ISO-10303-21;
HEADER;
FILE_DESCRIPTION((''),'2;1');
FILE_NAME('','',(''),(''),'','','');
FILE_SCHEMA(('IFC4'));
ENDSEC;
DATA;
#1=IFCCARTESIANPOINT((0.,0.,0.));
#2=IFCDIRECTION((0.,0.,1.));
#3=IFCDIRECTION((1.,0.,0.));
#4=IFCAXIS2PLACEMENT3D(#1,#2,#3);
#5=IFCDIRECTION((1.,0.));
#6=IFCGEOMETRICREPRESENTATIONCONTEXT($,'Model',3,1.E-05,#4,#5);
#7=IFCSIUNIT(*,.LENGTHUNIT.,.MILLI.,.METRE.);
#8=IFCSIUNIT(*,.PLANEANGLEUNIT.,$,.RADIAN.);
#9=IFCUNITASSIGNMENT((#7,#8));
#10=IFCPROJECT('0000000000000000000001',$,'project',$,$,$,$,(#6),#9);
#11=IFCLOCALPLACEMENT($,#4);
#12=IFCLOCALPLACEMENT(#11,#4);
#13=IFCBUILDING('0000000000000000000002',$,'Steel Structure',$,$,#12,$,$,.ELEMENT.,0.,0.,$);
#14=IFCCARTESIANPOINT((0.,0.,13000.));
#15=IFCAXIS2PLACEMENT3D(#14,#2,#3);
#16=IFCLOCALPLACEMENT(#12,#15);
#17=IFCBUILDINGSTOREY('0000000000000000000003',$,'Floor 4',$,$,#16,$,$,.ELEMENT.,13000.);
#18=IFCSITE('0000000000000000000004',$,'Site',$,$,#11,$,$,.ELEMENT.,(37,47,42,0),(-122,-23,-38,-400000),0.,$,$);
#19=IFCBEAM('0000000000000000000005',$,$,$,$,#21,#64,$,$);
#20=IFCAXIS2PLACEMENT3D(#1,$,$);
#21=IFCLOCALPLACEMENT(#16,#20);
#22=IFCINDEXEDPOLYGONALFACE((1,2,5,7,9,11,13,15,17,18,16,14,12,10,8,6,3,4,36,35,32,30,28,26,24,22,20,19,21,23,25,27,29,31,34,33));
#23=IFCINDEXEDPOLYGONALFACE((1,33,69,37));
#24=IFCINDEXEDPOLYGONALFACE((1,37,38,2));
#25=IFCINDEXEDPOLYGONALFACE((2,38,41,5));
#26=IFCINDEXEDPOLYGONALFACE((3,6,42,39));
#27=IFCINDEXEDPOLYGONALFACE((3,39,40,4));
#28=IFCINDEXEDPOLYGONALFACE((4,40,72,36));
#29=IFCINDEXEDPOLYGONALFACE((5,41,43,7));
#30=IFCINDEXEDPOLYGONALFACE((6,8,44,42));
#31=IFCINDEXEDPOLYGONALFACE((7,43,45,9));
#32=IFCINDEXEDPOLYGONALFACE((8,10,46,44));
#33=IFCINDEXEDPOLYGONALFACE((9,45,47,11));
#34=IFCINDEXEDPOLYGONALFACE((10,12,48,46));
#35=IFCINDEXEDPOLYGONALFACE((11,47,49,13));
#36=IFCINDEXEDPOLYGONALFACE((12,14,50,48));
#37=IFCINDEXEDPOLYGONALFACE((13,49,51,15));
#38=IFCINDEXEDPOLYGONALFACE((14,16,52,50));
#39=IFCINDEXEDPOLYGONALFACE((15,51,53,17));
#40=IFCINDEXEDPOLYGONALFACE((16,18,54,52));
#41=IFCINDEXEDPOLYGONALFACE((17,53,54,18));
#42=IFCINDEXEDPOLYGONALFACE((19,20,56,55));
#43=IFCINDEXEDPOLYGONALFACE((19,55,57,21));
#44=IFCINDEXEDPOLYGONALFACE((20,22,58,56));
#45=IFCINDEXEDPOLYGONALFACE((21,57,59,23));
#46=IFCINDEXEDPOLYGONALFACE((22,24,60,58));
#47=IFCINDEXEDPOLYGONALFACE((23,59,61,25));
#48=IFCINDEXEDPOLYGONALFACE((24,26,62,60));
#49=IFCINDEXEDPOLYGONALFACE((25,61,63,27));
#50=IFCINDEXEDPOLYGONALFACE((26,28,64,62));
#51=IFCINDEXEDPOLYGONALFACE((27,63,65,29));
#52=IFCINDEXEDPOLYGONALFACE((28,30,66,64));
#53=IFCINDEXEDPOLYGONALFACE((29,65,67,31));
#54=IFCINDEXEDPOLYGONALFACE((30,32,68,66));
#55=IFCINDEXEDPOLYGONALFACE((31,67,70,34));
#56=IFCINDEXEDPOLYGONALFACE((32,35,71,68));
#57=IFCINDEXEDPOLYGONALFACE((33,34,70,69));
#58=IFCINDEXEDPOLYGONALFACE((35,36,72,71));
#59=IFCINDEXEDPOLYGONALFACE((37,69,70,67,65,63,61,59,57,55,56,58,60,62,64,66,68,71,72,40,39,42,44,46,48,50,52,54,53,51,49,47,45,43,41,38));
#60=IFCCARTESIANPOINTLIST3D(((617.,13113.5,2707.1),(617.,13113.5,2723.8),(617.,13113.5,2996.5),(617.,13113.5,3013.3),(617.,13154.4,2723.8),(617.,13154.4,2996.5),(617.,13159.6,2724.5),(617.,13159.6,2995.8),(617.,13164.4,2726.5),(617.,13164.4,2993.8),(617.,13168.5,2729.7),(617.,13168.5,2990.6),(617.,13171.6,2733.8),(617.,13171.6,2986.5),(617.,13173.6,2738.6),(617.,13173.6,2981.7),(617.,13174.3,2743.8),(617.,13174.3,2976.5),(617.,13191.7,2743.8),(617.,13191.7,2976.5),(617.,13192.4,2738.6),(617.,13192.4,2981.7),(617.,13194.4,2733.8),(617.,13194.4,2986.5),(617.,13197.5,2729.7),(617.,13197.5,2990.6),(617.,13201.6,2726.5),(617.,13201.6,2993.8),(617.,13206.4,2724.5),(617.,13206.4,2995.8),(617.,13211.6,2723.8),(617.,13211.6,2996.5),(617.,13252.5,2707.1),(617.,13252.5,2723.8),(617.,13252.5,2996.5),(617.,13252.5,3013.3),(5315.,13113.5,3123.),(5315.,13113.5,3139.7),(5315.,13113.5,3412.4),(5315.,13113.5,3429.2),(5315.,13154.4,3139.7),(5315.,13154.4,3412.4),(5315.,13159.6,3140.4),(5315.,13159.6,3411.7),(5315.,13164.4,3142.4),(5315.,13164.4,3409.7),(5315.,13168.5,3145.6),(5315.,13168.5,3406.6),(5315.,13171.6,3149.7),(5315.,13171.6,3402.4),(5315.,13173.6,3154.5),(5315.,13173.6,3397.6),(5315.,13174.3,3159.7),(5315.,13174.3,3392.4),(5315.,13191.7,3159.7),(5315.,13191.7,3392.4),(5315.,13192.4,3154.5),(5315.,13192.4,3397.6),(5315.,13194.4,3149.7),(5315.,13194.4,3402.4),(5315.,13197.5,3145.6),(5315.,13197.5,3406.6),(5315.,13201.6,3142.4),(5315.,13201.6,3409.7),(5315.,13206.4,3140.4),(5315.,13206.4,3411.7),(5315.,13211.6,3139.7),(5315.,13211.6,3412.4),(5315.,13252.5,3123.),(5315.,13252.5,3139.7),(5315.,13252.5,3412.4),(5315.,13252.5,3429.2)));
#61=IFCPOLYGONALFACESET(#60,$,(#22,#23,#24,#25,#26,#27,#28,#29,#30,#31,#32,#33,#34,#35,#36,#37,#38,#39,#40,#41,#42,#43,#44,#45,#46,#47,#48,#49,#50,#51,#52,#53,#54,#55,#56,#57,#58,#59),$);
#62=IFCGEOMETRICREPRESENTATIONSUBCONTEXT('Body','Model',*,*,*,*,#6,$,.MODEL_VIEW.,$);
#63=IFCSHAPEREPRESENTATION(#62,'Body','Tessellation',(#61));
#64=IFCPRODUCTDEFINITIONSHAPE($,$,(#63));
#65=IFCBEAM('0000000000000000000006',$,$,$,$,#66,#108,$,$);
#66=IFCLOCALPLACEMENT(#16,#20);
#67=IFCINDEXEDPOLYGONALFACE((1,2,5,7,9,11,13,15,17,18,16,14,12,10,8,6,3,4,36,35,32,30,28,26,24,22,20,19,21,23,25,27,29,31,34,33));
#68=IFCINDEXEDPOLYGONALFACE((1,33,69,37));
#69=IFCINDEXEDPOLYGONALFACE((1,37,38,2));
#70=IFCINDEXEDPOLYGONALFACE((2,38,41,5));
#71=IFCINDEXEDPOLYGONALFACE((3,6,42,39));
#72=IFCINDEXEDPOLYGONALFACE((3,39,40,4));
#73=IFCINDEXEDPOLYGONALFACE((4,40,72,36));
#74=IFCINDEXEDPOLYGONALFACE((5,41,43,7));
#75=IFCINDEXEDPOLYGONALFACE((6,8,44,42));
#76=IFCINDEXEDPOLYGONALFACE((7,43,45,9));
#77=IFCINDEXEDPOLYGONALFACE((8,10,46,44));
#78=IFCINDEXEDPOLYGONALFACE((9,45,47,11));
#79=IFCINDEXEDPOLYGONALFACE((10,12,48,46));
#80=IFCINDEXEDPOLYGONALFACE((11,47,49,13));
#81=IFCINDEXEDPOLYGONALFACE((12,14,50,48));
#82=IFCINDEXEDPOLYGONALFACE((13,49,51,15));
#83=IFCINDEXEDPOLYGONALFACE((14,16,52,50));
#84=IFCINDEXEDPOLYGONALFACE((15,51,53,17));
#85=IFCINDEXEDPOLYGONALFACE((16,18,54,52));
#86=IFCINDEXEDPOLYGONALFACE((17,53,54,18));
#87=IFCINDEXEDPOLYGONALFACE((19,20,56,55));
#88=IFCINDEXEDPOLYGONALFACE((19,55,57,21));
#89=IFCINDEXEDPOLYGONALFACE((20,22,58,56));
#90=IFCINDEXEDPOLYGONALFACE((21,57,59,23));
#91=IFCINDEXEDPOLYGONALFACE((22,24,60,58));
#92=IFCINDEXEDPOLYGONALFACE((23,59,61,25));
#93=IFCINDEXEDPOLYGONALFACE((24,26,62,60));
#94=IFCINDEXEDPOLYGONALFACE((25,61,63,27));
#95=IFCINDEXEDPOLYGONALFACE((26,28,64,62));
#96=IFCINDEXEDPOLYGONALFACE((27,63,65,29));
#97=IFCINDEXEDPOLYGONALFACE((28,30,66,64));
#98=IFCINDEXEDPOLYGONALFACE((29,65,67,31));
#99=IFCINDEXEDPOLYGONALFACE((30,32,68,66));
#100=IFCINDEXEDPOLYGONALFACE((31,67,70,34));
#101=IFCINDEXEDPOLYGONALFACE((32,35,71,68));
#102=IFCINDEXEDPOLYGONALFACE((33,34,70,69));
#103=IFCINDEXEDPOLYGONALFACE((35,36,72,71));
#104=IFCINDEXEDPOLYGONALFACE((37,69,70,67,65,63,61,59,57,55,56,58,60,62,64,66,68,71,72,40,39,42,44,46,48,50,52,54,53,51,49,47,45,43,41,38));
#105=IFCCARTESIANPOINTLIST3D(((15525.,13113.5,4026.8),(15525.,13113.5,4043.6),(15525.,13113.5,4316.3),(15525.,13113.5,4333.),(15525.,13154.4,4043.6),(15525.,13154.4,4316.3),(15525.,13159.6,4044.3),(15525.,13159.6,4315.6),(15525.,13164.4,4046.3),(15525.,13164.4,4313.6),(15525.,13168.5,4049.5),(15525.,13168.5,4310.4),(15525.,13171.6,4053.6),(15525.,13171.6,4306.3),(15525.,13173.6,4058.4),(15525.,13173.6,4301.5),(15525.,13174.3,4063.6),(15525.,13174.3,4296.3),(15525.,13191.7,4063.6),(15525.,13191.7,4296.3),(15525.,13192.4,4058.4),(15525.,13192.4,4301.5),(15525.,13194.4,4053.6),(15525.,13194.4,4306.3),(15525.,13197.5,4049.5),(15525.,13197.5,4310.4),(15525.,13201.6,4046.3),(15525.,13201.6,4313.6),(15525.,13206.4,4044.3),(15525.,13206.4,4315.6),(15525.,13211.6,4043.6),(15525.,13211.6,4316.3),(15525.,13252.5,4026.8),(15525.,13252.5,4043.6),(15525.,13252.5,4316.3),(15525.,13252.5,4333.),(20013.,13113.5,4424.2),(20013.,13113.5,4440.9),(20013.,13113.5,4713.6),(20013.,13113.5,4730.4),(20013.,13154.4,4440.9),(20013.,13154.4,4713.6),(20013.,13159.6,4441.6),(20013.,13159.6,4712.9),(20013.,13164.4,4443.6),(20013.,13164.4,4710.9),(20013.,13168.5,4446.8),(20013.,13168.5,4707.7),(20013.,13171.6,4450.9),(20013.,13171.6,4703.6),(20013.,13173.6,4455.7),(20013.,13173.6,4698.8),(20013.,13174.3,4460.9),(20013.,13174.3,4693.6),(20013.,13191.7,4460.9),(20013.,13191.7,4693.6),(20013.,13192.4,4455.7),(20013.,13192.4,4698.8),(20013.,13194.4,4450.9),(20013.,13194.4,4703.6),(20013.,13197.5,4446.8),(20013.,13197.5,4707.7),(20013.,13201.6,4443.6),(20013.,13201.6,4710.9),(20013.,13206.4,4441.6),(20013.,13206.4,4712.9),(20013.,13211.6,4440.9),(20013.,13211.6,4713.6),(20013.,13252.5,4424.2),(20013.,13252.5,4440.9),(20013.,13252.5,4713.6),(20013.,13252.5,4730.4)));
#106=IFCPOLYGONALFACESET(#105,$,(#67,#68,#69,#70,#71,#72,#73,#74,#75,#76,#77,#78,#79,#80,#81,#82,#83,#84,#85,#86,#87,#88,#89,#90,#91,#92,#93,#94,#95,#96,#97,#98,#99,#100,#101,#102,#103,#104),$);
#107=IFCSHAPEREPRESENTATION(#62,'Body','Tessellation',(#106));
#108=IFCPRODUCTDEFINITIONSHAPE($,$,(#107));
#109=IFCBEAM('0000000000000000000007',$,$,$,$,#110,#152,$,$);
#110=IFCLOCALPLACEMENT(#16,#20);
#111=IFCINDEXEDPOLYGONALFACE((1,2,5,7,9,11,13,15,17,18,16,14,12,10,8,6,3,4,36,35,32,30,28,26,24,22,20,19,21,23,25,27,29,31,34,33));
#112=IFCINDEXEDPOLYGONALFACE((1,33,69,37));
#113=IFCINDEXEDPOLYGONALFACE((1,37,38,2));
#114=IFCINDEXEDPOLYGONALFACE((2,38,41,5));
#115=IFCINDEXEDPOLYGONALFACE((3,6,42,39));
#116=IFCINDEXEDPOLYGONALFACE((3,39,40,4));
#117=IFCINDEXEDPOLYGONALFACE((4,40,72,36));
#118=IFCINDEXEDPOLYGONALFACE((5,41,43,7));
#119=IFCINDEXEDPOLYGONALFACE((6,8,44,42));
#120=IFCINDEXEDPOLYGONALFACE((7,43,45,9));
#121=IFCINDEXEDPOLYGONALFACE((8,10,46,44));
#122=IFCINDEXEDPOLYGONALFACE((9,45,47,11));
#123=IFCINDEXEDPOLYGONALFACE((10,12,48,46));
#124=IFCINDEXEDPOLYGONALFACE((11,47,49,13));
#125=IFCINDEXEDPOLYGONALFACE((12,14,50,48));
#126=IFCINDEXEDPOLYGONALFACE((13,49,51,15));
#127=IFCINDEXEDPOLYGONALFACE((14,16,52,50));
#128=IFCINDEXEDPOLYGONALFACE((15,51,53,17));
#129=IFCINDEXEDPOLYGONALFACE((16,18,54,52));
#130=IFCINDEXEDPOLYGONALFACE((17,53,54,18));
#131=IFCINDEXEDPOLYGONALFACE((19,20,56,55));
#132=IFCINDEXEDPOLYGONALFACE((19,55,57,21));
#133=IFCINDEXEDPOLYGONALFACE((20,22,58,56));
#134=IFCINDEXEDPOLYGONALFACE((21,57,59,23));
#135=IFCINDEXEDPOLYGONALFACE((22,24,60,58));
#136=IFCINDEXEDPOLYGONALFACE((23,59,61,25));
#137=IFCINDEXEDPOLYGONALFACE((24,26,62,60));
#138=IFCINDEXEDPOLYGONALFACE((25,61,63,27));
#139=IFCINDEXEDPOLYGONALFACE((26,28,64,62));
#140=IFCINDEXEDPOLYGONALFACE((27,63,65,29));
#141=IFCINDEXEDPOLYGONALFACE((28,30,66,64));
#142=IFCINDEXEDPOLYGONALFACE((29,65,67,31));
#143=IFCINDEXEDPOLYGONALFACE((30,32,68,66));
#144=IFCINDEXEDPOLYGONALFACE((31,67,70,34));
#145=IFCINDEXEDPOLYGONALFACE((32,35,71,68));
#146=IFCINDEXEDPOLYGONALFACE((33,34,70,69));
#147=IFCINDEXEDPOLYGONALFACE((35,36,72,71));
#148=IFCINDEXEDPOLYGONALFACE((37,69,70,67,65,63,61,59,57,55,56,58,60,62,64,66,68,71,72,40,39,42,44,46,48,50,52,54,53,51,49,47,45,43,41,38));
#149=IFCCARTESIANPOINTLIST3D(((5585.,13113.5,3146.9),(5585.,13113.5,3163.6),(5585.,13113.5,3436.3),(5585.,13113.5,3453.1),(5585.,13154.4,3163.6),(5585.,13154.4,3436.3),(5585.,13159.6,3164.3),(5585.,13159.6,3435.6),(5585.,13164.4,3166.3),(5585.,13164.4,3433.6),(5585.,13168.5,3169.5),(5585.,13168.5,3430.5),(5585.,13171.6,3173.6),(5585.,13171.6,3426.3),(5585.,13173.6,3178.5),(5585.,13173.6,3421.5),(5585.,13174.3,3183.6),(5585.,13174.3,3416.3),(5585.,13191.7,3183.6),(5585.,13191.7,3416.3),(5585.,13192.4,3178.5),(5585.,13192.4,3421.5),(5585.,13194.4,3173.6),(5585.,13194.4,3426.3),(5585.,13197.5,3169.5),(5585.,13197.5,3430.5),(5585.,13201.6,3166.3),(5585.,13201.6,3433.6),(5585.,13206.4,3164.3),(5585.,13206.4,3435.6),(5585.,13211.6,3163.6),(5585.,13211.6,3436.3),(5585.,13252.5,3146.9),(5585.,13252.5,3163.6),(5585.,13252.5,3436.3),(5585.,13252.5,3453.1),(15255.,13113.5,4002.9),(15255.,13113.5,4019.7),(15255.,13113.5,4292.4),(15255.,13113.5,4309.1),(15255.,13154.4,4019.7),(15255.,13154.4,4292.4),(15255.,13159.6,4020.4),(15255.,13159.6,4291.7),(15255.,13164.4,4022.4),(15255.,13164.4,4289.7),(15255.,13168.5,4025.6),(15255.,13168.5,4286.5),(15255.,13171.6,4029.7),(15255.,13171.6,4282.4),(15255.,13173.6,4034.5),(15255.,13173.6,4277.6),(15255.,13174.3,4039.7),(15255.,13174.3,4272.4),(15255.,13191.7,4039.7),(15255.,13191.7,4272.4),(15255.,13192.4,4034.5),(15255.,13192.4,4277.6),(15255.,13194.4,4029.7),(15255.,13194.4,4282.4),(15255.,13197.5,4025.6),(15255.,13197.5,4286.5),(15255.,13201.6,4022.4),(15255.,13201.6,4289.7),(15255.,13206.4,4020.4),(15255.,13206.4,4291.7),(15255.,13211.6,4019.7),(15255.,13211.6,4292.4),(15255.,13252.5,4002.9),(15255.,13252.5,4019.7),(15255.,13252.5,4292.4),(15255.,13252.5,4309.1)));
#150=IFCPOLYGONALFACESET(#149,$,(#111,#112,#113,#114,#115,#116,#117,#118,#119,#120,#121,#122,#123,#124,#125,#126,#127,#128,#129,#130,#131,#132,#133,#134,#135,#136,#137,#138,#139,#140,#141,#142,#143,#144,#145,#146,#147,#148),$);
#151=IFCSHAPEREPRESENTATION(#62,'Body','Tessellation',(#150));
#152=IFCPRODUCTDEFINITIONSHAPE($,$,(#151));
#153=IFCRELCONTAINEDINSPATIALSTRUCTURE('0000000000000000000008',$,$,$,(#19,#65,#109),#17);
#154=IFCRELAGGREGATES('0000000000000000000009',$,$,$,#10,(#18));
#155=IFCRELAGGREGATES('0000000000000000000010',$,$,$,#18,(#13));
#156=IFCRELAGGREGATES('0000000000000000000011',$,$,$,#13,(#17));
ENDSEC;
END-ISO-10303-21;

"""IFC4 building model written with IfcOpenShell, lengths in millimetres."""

from ifc_helpers import new_model, si_unit, direction, frame, origin_with_axes, origin_2d_with_axis, place, context, subcontext, project, spatial, polyline, i_section, extrude, clip, bounded_halfspace, element, save


model = new_model("IFC4")

# Units and contexts
model_context = context("Model", 3, precision=1e-05, world=origin_with_axes(), true_north=direction((1.0, 0.0)))
body_context = subcontext(model_context, "Body", "Model", "MODEL_VIEW")
ifc_project = project(units=[si_unit("LENGTHUNIT", "METRE", prefix="MILLI"), si_unit("PLANEANGLEUNIT", "RADIAN")], contexts=[model_context])

# Site, building, storey
site_placement = place(None, origin_with_axes())
site = spatial("IfcSite", under=ifc_project, at=site_placement, Name="Site", CompositionType="ELEMENT", RefLatitude=(37, 47, 42, 0), RefLongitude=(-122, -23, -38, -400000), RefElevation=0.0)
building_placement = place(site_placement, origin_with_axes())
building = spatial("IfcBuilding", under=site, at=building_placement, Name="Steel Structure", CompositionType="ELEMENT", ElevationOfRefHeight=0.0, ElevationOfTerrain=0.0)
storey_placement = place(building_placement, frame((0.0, 0.0, 13000.0), z_axis=(0.0, 0.0, 1.0), x_axis=(1.0, 0.0, 0.0)))
storey = spatial("IfcBuildingStorey", under=building, at=storey_placement, Name="Floor 4", CompositionType="ELEMENT", Elevation=13000.0)

# Beams
beam_1_placement = place(storey_placement, frame((617.0, 13183.0, 2707.1), z_axis=(0.996104, 0.0, 0.088184), x_axis=(0.0, 1.0, 0.0)))
element("IfcBeam", 1, at=beam_1_placement, inside=storey, context=body_context, shape_type="Clipping", body=[
    clip(clip(extrude(i_section(OverallWidth=139.0, OverallDepth=305.0, WebThickness=17.4, FlangeThickness=16.7, FilletRadius=19.9, at=origin_2d_with_axis()), frame((0.0, 152.5, 0.0), z_axis=(0.0, 0.0, 1.0), x_axis=(1.0, 0.0, 0.0)), (0.0, 0.0, 1.0), 4743.4), bounded_halfspace(frame((-13183.0, -15645.9, -1385.1), z_axis=(0.0, 0.088184, -0.996104), x_axis=(-1.0, 0.0, 0.0)), False, frame((0.0, 152.5, 0.0), z_axis=(0.0, 0.0, 1.0), x_axis=(1.0, 0.0, 0.0)), polyline([(69.5, 152.5), (69.5, 135.8), (28.6, 135.8), (8.7, 115.9), (8.7, -115.9), (28.6, -135.8), (69.5, -135.8), (69.5, -152.5), (-69.5, -152.5), (-69.5, -135.8), (-28.6, -135.8), (-8.7, -115.9), (-8.7, 115.9), (-28.6, 135.8), (-69.5, 135.8), (-69.5, 152.5), (69.5, 152.5)]))), bounded_halfspace(frame((-13183.0, -16060.2, 3294.6), z_axis=(0.0, -0.088184, 0.996104), x_axis=(1.0, 0.0, 0.0)), False, frame((0.0, 152.5, 0.0), z_axis=(0.0, 0.0, 1.0), x_axis=(1.0, 0.0, 0.0)), polyline([(-69.5, -135.8), (-69.5, -152.5), (69.5, -152.5), (69.5, -135.8), (28.6, -135.8), (8.7, -115.9), (8.7, 115.9), (28.6, 135.8), (69.5, 135.8), (69.5, 152.5), (-69.5, 152.5), (-69.5, 135.8), (-28.6, 135.8), (-8.7, 115.9), (-8.7, -115.9), (-28.6, -135.8), (-69.5, -135.8)]))),
])
beam_2_placement = place(storey_placement, frame((15525.0, 13183.0, 4026.8), z_axis=(0.996104, 0.0, 0.088184), x_axis=(0.0, 1.0, 0.0)))
element("IfcBeam", 2, at=beam_2_placement, inside=storey, context=body_context, shape_type="Clipping", body=[
    clip(clip(extrude(i_section(OverallWidth=139.0, OverallDepth=305.0, WebThickness=17.4, FlangeThickness=16.7, FilletRadius=19.9, at=origin_2d_with_axis()), frame((0.0, 152.5, 0.0), z_axis=(0.0, 0.0, 1.0), x_axis=(1.0, 0.0, 0.0)), (0.0, 0.0, 1.0), 4532.6), bounded_halfspace(frame((-13183.0, -16960.5, -1501.5), z_axis=(0.0, 0.088184, -0.996104), x_axis=(-1.0, 0.0, 0.0)), False, frame((0.0, 152.5, 0.0), z_axis=(0.0, 0.0, 1.0), x_axis=(1.0, 0.0, 0.0)), polyline([(-69.5, -152.5), (-69.5, -135.8), (-28.6, -135.8), (-8.7, -115.9), (-8.7, 115.9), (-28.6, 135.8), (-69.5, 135.8), (-69.5, 152.5), (69.5, 152.5), (69.5, 135.8), (28.6, 135.8), (8.7, 115.9), (8.7, -115.9), (28.6, -135.8), (69.5, -135.8), (69.5, -152.5), (-69.5, -152.5)]))), bounded_halfspace(frame((-13183.0, -17356.3, 2969.1), z_axis=(0.0, -0.088184, 0.996104), x_axis=(1.0, 0.0, 0.0)), False, frame((0.0, 152.5, 0.0), z_axis=(0.0, 0.0, 1.0), x_axis=(1.0, 0.0, 0.0)), polyline([(69.5, 135.8), (69.5, 152.5), (-69.5, 152.5), (-69.5, 135.8), (-28.6, 135.8), (-8.7, 115.9), (-8.7, -115.9), (-28.6, -135.8), (-69.5, -135.8), (-69.5, -152.5), (69.5, -152.5), (69.5, -135.8), (28.6, -135.8), (8.7, -115.9), (8.7, 115.9), (28.6, 135.8), (69.5, 135.8)]))),
])
beam_3_placement = place(storey_placement, frame((5585.0, 13183.0, 3146.9), z_axis=(0.996104, 0.0, 0.088184), x_axis=(0.0, 1.0, 0.0)))
element("IfcBeam", 3, at=beam_3_placement, inside=storey, context=body_context, shape_type="Clipping", body=[
    clip(clip(extrude(i_section(OverallWidth=139.0, OverallDepth=305.0, WebThickness=17.4, FlangeThickness=16.7, FilletRadius=19.9, at=origin_2d_with_axis()), frame((0.0, 152.5, 0.0), z_axis=(0.0, 0.0, 1.0), x_axis=(1.0, 0.0, 0.0)), (0.0, 0.0, 1.0), 9734.8), bounded_halfspace(frame((-13183.0, -16084.0, -1423.9), z_axis=(0.0, 0.088184, -0.996104), x_axis=(-1.0, 0.0, 0.0)), False, frame((0.0, 152.5, 0.0), z_axis=(0.0, 0.0, 1.0), x_axis=(1.0, 0.0, 0.0)), polyline([(69.5, 152.5), (69.5, 135.8), (28.6, 135.8), (8.7, 115.9), (8.7, -115.9), (28.6, -135.8), (69.5, -135.8), (69.5, -152.5), (-69.5, -152.5), (-69.5, -135.8), (-28.6, -135.8), (-8.7, -115.9), (-8.7, 115.9), (-28.6, 135.8), (-69.5, 135.8), (-69.5, 152.5), (69.5, 152.5)]))), bounded_halfspace(frame((-13183.0, -16936.7, 8208.4), z_axis=(0.0, -0.088184, 0.996104), x_axis=(1.0, 0.0, 0.0)), False, frame((0.0, 152.5, 0.0), z_axis=(0.0, 0.0, 1.0), x_axis=(1.0, 0.0, 0.0)), polyline([(69.5, 135.8), (69.5, 152.5), (-69.5, 152.5), (-69.5, 135.8), (-28.6, 135.8), (-8.7, 115.9), (-8.7, -115.9), (-28.6, -135.8), (-69.5, -135.8), (-69.5, -152.5), (69.5, -152.5), (69.5, -135.8), (28.6, -135.8), (8.7, -115.9), (8.7, 115.9), (28.6, 135.8), (69.5, 135.8)]))),
])

save(model, "model.ifc")
